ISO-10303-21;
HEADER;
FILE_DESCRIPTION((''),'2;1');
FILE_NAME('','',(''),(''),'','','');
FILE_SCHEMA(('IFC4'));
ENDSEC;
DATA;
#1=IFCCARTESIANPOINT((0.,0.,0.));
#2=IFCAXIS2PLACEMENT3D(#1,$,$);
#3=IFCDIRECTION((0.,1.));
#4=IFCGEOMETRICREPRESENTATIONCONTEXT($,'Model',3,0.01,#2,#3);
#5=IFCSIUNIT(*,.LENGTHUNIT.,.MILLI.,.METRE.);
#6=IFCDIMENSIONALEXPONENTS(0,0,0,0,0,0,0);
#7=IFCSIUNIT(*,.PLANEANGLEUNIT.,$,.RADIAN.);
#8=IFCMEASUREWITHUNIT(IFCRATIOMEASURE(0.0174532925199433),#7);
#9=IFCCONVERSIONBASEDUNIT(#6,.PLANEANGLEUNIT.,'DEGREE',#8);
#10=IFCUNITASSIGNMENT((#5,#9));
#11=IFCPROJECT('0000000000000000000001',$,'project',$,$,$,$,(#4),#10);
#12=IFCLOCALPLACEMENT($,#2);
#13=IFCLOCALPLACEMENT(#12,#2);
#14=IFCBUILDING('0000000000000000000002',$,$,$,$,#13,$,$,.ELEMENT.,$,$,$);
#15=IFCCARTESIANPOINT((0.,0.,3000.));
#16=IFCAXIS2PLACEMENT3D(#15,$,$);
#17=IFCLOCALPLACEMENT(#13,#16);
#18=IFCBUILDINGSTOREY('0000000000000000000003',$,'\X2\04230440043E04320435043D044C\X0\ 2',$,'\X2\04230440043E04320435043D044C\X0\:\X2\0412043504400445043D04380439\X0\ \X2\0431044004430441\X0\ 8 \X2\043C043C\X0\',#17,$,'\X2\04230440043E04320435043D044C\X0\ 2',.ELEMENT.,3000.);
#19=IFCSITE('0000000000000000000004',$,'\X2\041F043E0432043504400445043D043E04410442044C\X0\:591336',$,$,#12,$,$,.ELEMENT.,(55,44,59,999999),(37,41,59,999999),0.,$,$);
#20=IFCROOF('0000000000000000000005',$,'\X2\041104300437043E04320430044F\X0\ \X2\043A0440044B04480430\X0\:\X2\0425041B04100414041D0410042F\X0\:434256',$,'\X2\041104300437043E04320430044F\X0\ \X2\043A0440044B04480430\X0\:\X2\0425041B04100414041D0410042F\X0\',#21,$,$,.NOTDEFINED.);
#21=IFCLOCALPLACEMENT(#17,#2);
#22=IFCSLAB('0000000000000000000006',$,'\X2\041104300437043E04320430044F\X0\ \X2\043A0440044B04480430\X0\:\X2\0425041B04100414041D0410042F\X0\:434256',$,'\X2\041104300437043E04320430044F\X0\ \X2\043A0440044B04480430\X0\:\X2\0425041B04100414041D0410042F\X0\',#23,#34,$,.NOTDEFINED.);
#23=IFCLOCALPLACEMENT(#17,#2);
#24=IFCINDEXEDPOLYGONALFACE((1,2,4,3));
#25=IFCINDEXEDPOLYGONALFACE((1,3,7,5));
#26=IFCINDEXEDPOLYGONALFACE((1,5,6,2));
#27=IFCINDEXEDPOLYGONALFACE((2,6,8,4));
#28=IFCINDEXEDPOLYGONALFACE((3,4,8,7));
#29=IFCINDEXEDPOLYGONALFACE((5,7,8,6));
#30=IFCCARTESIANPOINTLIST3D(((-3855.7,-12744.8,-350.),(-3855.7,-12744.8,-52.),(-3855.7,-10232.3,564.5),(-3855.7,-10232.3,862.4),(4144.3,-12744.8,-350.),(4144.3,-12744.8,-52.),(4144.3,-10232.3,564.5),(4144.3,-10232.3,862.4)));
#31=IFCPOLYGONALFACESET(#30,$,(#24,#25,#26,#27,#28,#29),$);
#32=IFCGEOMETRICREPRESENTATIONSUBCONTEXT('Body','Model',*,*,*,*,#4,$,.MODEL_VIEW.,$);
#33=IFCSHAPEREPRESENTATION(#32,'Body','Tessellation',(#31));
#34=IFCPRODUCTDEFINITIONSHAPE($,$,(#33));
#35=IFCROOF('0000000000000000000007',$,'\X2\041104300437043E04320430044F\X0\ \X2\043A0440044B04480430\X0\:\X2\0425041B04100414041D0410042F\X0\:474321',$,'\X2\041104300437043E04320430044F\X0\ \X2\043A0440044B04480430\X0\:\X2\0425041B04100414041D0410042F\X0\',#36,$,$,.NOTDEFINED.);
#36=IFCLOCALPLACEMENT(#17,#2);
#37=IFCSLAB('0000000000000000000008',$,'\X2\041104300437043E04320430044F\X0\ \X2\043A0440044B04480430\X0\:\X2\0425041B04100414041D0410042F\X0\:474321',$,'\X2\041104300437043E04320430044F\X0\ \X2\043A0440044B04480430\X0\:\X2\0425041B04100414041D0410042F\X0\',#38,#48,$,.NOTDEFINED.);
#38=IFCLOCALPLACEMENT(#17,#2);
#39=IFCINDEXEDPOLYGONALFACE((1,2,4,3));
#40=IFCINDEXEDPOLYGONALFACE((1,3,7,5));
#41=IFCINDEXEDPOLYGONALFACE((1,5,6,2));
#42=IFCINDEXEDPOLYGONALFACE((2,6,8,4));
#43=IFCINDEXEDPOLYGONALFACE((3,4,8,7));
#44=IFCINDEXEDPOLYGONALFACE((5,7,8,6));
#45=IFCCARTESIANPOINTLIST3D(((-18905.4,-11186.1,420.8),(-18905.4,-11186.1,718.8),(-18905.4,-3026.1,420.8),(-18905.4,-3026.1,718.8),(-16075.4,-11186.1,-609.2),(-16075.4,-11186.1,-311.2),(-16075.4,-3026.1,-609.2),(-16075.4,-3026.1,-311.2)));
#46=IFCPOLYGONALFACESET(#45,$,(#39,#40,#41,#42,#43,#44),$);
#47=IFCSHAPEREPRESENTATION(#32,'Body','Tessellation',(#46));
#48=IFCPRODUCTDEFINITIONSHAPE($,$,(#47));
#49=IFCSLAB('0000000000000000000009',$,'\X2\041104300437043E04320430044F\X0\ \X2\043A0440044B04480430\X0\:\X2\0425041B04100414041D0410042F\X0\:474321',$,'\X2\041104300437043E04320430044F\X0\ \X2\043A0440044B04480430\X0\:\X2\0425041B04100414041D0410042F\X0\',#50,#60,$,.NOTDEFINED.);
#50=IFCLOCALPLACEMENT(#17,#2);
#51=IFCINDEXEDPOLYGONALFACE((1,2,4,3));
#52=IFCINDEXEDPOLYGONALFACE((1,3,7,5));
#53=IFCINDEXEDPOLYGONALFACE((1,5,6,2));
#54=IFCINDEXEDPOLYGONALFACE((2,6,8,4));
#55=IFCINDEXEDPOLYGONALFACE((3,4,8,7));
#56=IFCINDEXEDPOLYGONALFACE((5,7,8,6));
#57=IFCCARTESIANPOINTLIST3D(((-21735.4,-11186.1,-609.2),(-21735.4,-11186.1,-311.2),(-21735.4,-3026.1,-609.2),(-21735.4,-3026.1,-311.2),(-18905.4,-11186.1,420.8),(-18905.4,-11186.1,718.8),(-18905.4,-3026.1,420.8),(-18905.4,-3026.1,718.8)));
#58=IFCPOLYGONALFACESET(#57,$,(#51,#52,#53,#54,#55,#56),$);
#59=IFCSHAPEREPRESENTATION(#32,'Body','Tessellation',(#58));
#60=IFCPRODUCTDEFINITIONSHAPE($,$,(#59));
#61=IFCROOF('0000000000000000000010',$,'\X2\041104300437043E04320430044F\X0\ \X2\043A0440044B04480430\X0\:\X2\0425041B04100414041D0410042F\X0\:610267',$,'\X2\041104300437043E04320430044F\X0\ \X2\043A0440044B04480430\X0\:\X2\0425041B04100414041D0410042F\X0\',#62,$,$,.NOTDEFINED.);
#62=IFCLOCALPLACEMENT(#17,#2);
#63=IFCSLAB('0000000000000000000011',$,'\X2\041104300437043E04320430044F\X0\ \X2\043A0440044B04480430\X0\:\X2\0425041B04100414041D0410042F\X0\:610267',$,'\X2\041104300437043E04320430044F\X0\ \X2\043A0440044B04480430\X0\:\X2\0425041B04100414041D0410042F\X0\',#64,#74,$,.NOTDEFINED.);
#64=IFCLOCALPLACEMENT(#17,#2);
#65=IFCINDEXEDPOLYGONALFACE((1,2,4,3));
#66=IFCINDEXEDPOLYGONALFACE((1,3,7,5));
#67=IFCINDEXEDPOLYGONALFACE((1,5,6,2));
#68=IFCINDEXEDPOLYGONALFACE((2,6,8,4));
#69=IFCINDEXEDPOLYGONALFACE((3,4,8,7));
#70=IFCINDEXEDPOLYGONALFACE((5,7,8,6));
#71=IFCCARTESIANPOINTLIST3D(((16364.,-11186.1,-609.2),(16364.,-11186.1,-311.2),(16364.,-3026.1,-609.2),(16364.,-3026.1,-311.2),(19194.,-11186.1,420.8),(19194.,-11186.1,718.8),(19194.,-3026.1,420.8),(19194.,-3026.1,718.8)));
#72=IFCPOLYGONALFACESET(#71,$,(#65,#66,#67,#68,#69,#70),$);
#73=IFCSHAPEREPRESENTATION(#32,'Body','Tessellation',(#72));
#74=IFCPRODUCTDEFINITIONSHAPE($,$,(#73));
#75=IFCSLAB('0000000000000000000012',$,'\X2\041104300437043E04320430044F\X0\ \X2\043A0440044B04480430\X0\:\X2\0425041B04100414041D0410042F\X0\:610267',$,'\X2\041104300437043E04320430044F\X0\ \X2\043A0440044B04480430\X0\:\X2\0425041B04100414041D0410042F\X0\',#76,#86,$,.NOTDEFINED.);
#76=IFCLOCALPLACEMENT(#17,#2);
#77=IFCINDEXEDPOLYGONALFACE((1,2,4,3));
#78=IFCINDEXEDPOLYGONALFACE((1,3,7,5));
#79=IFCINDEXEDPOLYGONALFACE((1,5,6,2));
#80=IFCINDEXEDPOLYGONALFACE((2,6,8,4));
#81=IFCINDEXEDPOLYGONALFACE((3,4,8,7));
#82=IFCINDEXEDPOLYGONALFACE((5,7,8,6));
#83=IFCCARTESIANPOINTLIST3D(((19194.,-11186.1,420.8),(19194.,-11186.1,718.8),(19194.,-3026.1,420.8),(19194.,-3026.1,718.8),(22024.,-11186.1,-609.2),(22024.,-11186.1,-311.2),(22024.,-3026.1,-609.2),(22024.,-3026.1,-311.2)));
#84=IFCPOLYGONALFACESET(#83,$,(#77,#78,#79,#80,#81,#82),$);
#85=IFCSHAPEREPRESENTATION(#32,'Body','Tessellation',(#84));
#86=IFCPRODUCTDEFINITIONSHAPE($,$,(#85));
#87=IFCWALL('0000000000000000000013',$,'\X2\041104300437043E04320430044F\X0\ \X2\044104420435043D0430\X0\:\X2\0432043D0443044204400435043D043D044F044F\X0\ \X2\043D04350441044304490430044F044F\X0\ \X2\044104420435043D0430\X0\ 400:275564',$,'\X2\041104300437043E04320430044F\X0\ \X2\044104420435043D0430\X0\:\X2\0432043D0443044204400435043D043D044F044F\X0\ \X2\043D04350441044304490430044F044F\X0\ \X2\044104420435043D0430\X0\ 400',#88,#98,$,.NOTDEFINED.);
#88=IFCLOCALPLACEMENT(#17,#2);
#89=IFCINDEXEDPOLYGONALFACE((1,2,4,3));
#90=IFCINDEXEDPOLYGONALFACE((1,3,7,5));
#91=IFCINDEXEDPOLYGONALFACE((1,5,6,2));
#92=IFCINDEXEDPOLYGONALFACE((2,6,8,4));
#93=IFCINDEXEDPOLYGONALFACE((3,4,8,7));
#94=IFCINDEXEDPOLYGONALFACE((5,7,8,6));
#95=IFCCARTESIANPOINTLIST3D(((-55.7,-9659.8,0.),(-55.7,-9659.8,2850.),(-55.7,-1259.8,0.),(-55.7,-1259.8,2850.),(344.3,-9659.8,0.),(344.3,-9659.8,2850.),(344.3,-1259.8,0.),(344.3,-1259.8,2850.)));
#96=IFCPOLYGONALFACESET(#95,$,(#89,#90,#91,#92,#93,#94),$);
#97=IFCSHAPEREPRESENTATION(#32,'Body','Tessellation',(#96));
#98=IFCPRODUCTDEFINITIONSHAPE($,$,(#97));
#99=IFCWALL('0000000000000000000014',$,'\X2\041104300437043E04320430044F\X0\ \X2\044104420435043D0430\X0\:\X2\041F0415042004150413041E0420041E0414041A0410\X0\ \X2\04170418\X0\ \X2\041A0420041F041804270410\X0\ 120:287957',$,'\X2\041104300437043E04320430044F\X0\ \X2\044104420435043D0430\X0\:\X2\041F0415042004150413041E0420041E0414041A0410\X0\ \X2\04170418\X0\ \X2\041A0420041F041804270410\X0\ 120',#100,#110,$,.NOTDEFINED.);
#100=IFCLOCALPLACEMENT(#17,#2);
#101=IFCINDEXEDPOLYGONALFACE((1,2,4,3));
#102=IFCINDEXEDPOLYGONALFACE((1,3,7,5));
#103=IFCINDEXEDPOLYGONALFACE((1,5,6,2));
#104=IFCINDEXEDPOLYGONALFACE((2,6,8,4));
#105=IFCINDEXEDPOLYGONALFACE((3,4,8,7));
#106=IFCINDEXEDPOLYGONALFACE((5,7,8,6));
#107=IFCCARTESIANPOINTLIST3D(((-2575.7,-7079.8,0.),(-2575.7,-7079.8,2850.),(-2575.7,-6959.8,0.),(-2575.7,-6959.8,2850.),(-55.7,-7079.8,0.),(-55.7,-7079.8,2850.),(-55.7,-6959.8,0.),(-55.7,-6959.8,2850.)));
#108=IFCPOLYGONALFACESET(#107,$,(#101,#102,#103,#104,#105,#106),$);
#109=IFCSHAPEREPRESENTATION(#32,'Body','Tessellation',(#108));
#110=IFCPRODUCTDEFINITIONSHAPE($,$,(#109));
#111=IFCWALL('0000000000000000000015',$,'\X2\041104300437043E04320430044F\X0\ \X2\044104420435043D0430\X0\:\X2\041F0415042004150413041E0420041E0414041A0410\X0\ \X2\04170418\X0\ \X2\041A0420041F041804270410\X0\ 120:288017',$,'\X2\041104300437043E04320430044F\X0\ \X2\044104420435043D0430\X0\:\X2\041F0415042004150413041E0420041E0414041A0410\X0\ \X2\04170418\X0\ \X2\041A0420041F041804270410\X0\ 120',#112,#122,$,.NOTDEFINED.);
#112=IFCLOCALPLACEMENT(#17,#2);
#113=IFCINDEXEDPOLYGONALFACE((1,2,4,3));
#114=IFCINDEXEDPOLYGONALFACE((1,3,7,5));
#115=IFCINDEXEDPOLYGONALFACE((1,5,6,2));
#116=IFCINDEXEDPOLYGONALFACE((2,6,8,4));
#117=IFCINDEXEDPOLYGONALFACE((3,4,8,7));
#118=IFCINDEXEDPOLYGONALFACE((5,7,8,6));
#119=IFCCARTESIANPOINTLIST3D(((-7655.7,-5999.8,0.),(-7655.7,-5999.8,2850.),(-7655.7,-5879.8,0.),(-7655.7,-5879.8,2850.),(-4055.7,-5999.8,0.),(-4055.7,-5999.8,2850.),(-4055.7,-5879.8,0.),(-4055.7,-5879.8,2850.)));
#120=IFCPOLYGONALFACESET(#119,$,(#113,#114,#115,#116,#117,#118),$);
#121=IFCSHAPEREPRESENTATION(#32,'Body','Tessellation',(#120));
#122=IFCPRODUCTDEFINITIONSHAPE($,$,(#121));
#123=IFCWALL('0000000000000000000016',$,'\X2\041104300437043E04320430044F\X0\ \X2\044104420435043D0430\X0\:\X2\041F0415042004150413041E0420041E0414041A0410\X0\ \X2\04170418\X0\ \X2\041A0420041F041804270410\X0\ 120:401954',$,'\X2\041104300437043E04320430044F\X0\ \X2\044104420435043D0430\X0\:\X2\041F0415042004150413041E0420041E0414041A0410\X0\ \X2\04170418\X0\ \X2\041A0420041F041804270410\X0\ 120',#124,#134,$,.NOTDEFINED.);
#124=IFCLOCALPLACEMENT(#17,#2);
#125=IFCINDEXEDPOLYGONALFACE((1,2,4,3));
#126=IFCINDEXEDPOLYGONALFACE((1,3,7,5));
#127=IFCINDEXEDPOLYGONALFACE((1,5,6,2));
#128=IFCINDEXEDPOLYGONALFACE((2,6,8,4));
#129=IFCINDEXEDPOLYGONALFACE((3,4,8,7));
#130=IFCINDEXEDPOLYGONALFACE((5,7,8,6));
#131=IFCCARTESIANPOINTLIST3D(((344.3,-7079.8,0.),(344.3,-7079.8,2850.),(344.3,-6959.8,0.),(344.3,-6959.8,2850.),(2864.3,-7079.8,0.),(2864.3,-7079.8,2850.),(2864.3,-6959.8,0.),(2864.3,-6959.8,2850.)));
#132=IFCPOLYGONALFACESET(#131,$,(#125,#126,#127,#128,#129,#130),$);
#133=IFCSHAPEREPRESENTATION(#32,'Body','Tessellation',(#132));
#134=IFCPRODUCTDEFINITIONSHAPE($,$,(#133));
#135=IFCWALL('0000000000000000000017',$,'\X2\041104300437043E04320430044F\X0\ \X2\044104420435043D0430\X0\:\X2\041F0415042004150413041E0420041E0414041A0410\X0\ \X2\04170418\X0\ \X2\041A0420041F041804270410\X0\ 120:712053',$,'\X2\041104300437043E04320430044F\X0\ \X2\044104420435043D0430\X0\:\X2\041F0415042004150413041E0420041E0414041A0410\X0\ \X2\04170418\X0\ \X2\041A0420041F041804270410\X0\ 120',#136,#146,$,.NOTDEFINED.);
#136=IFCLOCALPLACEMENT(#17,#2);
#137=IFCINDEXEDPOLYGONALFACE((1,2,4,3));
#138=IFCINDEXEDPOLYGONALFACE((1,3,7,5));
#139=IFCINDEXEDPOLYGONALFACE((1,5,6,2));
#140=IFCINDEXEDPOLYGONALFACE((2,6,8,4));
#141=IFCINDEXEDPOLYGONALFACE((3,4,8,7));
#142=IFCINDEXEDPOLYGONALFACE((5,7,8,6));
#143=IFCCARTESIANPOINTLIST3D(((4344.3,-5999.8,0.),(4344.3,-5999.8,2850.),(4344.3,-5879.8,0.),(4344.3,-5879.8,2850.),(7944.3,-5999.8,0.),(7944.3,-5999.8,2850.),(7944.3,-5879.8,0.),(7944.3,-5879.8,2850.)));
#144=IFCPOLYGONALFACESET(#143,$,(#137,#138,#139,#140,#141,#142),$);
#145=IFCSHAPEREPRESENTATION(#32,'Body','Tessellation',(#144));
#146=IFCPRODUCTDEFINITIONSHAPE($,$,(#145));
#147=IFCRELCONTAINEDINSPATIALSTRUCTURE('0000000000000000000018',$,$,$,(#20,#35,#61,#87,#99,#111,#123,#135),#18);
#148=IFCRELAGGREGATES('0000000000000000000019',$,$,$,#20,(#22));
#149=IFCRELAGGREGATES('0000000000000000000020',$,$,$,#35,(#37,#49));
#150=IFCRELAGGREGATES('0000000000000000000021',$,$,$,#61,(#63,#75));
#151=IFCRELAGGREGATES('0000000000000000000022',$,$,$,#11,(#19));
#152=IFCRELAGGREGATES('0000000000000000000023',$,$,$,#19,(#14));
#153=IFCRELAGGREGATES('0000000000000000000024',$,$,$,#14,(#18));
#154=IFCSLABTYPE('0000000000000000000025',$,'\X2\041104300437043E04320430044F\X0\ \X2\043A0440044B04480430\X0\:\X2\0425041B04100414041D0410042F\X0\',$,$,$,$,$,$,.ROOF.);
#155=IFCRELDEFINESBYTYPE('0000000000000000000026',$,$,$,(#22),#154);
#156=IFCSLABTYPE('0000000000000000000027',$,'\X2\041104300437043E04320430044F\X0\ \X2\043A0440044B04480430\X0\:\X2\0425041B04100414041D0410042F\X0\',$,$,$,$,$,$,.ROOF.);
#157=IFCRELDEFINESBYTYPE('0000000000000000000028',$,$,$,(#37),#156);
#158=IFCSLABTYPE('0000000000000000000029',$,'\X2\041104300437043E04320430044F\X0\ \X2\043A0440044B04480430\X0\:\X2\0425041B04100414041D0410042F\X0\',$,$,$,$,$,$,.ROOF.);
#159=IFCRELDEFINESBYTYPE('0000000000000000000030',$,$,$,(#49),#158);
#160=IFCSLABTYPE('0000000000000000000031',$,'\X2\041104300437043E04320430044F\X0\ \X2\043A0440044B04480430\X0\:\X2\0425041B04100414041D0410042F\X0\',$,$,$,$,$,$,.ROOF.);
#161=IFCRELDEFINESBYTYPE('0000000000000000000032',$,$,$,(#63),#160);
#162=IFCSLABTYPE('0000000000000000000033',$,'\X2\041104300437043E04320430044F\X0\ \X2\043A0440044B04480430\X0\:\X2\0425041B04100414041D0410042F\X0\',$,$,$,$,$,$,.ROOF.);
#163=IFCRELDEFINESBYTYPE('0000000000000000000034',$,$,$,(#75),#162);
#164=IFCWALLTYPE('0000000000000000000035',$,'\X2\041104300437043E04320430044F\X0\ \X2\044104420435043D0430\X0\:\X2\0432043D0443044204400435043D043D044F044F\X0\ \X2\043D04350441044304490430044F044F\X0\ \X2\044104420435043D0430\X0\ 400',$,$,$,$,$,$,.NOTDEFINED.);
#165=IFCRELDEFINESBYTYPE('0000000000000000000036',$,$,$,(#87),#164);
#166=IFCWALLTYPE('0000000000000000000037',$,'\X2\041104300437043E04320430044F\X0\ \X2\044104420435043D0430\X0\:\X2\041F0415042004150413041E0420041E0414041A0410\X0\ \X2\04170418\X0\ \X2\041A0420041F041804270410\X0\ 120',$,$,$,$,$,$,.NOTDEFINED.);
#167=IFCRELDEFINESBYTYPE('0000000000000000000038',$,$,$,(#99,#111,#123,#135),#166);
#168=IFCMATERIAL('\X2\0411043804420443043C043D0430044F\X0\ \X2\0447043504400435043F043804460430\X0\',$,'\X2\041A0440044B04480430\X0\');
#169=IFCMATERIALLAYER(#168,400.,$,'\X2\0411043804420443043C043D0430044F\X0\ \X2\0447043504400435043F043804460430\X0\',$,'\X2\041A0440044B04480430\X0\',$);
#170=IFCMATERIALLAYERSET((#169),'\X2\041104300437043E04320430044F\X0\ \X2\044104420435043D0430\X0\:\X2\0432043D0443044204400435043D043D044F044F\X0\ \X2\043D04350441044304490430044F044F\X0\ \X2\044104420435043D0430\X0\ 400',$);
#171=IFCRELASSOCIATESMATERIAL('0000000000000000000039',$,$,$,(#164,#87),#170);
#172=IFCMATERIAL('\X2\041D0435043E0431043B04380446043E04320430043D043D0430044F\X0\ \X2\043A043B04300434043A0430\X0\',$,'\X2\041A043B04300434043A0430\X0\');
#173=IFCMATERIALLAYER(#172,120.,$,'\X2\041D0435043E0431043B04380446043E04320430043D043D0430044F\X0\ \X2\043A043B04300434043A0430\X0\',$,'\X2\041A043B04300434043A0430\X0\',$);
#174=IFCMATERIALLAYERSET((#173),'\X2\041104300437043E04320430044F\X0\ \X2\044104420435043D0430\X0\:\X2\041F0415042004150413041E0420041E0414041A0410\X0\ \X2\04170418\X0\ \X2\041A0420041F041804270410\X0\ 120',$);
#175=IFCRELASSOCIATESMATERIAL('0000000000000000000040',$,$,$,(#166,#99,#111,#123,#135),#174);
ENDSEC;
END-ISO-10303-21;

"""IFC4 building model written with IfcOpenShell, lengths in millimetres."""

from ifc_helpers import new_model, entity, si_unit, converted_unit, direction, frame, origin, place, context, subcontext, project, spatial, indexed_curve, outline, extrude, material, layer, layer_set, type_object, element, aggregate, save


model = new_model("IFC4")

# Units and contexts
model_context = context("Model", 3, precision=0.01, world=origin(), true_north=direction((0.0, 1.0)))
body_context = subcontext(model_context, "Body", "Model", "MODEL_VIEW")
ifc_project = project(units=[si_unit("LENGTHUNIT", "METRE", prefix="MILLI"), converted_unit("PLANEANGLEUNIT", "DEGREE", entity("IfcRatioMeasure", 0.0174532925199433), si_unit("PLANEANGLEUNIT", "RADIAN"), dimensions=[0, 0, 0, 0, 0, 0, 0])], contexts=[model_context])

# Site, building, storey
site_placement = place(None, origin())
site = spatial("IfcSite", under=ifc_project, at=site_placement, Name="Поверхность:591336", CompositionType="ELEMENT", RefLatitude=(55, 44, 59, 999999), RefLongitude=(37, 41, 59, 999999), RefElevation=0.0)
building_placement = place(site_placement, origin())
building = spatial("IfcBuilding", under=site, at=building_placement, CompositionType="ELEMENT")
storey_placement = place(building_placement, frame((0.0, 0.0, 3000.0)))
storey = spatial("IfcBuildingStorey", under=building, at=storey_placement, Name="Уровень 2", ObjectType="Уровень:Верхний брус 8 мм", LongName="Уровень 2", CompositionType="ELEMENT", Elevation=3000.0)

# Roof, slab
roof_1_placement = place(storey_placement, frame((-3855.7, -12744.8, -350.0)))
roof_1 = element("IfcRoof", 1, at=roof_1_placement, inside=storey, Name="Базовая крыша:ХЛАДНАЯ:434256", ObjectType="Базовая крыша:ХЛАДНАЯ", PredefinedType="NOTDEFINED")
slab_type_1 = type_object("IfcSlabType", Name="Базовая крыша:ХЛАДНАЯ", PredefinedType="ROOF")
slab_1_placement = place(roof_1_placement, origin())
slab_1 = element("IfcSlab", 2, at=slab_1_placement, type_object=slab_type_1, Name="Базовая крыша:ХЛАДНАЯ:434256", ObjectType="Базовая крыша:ХЛАДНАЯ", PredefinedType="NOTDEFINED", context=body_context, shape_type="SweptSolid", body=[
    extrude(outline(indexed_curve([(-4000.0, 1336.9), (-4000.0, -1336.9), (4000.0, -1336.9), (4000.0, 1336.9), (-4000.0, 1336.9)], self_intersect=False)), frame((4000.0, 1256.2, 457.2), z_axis=(0.0, -0.34202, 0.939693), x_axis=(1.0, 0.0, 0.0)), (0.0, 0.34202, 0.939693), 298.0),
])
aggregate(roof_1, [slab_1])

# Roofs, slabs
roof_2_placement = place(storey_placement, frame((-21735.4, -11186.1, -609.2)))
roof_2 = element("IfcRoof", 3, at=roof_2_placement, inside=storey, Name="Базовая крыша:ХЛАДНАЯ:474321", ObjectType="Базовая крыша:ХЛАДНАЯ", PredefinedType="NOTDEFINED")
slab_type_2 = type_object("IfcSlabType", Name="Базовая крыша:ХЛАДНАЯ", PredefinedType="ROOF")
slab_2_placement = place(roof_2_placement, origin())
slab_2 = element("IfcSlab", 4, at=slab_2_placement, type_object=slab_type_2, Name="Базовая крыша:ХЛАДНАЯ:474321", ObjectType="Базовая крыша:ХЛАДНАЯ", PredefinedType="NOTDEFINED", context=body_context, shape_type="SweptSolid", body=[
    extrude(outline(indexed_curve([(-1505.8, 4080.0), (-1505.8, -4080.0), (1505.8, -4080.0), (1505.8, 4080.0), (-1505.8, 4080.0)], self_intersect=False)), frame((4245.0, 4080.0, 515.0), z_axis=(0.34202, 0.0, 0.939693), x_axis=(0.939693, 0.0, -0.34202)), (-0.34202, 0.0, 0.939693), 298.0),
])
slab_type_3 = type_object("IfcSlabType", Name="Базовая крыша:ХЛАДНАЯ", PredefinedType="ROOF")
slab_3_placement = place(roof_2_placement, origin())
slab_3 = element("IfcSlab", 5, at=slab_3_placement, type_object=slab_type_3, Name="Базовая крыша:ХЛАДНАЯ:474321", ObjectType="Базовая крыша:ХЛАДНАЯ", PredefinedType="NOTDEFINED", context=body_context, shape_type="SweptSolid", body=[
    extrude(outline(indexed_curve([(-1505.8, -4080.0), (1505.8, -4080.0), (1505.8, 4080.0), (-1505.8, 4080.0), (-1505.8, -4080.0)], self_intersect=False)), frame((1415.0, 4080.0, 515.0), z_axis=(-0.34202, 0.0, 0.939693), x_axis=(0.939693, 0.0, 0.34202)), (0.34202, 0.0, 0.939693), 298.0),
])
aggregate(roof_2, [slab_2, slab_3])
roof_3_placement = place(storey_placement, frame((16364.0, -11186.1, -609.2)))
roof_3 = element("IfcRoof", 6, at=roof_3_placement, inside=storey, Name="Базовая крыша:ХЛАДНАЯ:610267", ObjectType="Базовая крыша:ХЛАДНАЯ", PredefinedType="NOTDEFINED")
slab_type_4 = type_object("IfcSlabType", Name="Базовая крыша:ХЛАДНАЯ", PredefinedType="ROOF")
slab_4_placement = place(roof_3_placement, origin())
slab_4 = element("IfcSlab", 7, at=slab_4_placement, type_object=slab_type_4, Name="Базовая крыша:ХЛАДНАЯ:610267", ObjectType="Базовая крыша:ХЛАДНАЯ", PredefinedType="NOTDEFINED", context=body_context, shape_type="SweptSolid", body=[
    extrude(outline(indexed_curve([(-1505.8, -4080.0), (1505.8, -4080.0), (1505.8, 4080.0), (-1505.8, 4080.0), (-1505.8, -4080.0)], self_intersect=False)), frame((1415.0, 4080.0, 515.0), z_axis=(-0.34202, 0.0, 0.939693), x_axis=(0.939693, 0.0, 0.34202)), (0.34202, 0.0, 0.939693), 298.0),
])
slab_type_5 = type_object("IfcSlabType", Name="Базовая крыша:ХЛАДНАЯ", PredefinedType="ROOF")
slab_5_placement = place(roof_3_placement, origin())
slab_5 = element("IfcSlab", 8, at=slab_5_placement, type_object=slab_type_5, Name="Базовая крыша:ХЛАДНАЯ:610267", ObjectType="Базовая крыша:ХЛАДНАЯ", PredefinedType="NOTDEFINED", context=body_context, shape_type="SweptSolid", body=[
    extrude(outline(indexed_curve([(-1505.8, 4080.0), (-1505.8, -4080.0), (1505.8, -4080.0), (1505.8, 4080.0), (-1505.8, 4080.0)], self_intersect=False)), frame((4245.0, 4080.0, 515.0), z_axis=(0.34202, 0.0, 0.939693), x_axis=(0.939693, 0.0, -0.34202)), (-0.34202, 0.0, 0.939693), 298.0),
])
aggregate(roof_3, [slab_4, slab_5])

# Walls
ifc_material_1 = material(Name="Битумная черепица", Category="Крыша")
ifc_layer_1 = layer(ifc_material_1, 400.0, Name="Битумная черепица", Category="Крыша")
ifc_layer_set_1 = layer_set([ifc_layer_1], Name="Базовая стена:внутренняя несущаяя стена 400")
wall_type_1 = type_object("IfcWallType", Name="Базовая стена:внутренняя несущаяя стена 400", PredefinedType="NOTDEFINED", material=ifc_layer_set_1)
wall_1_placement = place(storey_placement, frame((144.3, -1259.8, 0.0), z_axis=(0.0, 0.0, 1.0), x_axis=(0.0, -1.0, 0.0)))
element("IfcWall", 9, at=wall_1_placement, inside=storey, type_object=wall_type_1, material=ifc_layer_set_1, Name="Базовая стена:внутренняя несущаяя стена 400:275564", ObjectType="Базовая стена:внутренняя несущаяя стена 400", PredefinedType="NOTDEFINED", context=body_context, shape_type="SweptSolid", body=[
    extrude(outline(indexed_curve([(8400.0, 200.0), (0.0, 200.0), (0.0, -200.0), (8400.0, -200.0), (8400.0, 200.0)], self_intersect=False)), origin(), (0.0, 0.0, 1.0), 2850.0),
])
ifc_material_2 = material(Name="Необлицованная кладка", Category="Кладка")
ifc_layer_2 = layer(ifc_material_2, 120.0, Name="Необлицованная кладка", Category="Кладка")
ifc_layer_set_2 = layer_set([ifc_layer_2], Name="Базовая стена:ПЕРЕГОРОДКА ЗИ КРПИЧА 120")
wall_type_2 = type_object("IfcWallType", Name="Базовая стена:ПЕРЕГОРОДКА ЗИ КРПИЧА 120", PredefinedType="NOTDEFINED", material=ifc_layer_set_2)
wall_2_placement = place(storey_placement, frame((-2575.7, -7019.8, 0.0)))
element("IfcWall", 10, at=wall_2_placement, inside=storey, type_object=wall_type_2, material=ifc_layer_set_2, Name="Базовая стена:ПЕРЕГОРОДКА ЗИ КРПИЧА 120:287957", ObjectType="Базовая стена:ПЕРЕГОРОДКА ЗИ КРПИЧА 120", PredefinedType="NOTDEFINED", context=body_context, shape_type="SweptSolid", body=[
    extrude(outline(indexed_curve([(2520.0, 60.0), (0.0, 60.0), (0.0, -60.0), (2520.0, -60.0), (2520.0, 60.0)], self_intersect=False)), origin(), (0.0, 0.0, 1.0), 2850.0),
])
wall_3_placement = place(storey_placement, frame((-4055.7, -5939.8, 0.0), z_axis=(0.0, 0.0, 1.0), x_axis=(-1.0, 0.0, 0.0)))
element("IfcWall", 11, at=wall_3_placement, inside=storey, type_object=wall_type_2, material=ifc_layer_set_2, Name="Базовая стена:ПЕРЕГОРОДКА ЗИ КРПИЧА 120:288017", ObjectType="Базовая стена:ПЕРЕГОРОДКА ЗИ КРПИЧА 120", PredefinedType="NOTDEFINED", context=body_context, shape_type="SweptSolid", body=[
    extrude(outline(indexed_curve([(3600.0, 60.0), (0.0, 60.0), (0.0, -60.0), (3600.0, -60.0), (3600.0, 60.0)], self_intersect=False)), origin(), (0.0, 0.0, 1.0), 2850.0),
])
wall_4_placement = place(storey_placement, frame((2864.3, -7019.8, 0.0), z_axis=(0.0, 0.0, 1.0), x_axis=(-1.0, 0.0, 0.0)))
element("IfcWall", 12, at=wall_4_placement, inside=storey, type_object=wall_type_2, material=ifc_layer_set_2, Name="Базовая стена:ПЕРЕГОРОДКА ЗИ КРПИЧА 120:401954", ObjectType="Базовая стена:ПЕРЕГОРОДКА ЗИ КРПИЧА 120", PredefinedType="NOTDEFINED", context=body_context, shape_type="SweptSolid", body=[
    extrude(outline(indexed_curve([(2520.0, 60.0), (0.0, 60.0), (0.0, -60.0), (2520.0, -60.0), (2520.0, 60.0)], self_intersect=False)), origin(), (0.0, 0.0, 1.0), 2850.0),
])
wall_5_placement = place(storey_placement, frame((4344.3, -5939.8, 0.0)))
element("IfcWall", 13, at=wall_5_placement, inside=storey, type_object=wall_type_2, material=ifc_layer_set_2, Name="Базовая стена:ПЕРЕГОРОДКА ЗИ КРПИЧА 120:712053", ObjectType="Базовая стена:ПЕРЕГОРОДКА ЗИ КРПИЧА 120", PredefinedType="NOTDEFINED", context=body_context, shape_type="SweptSolid", body=[
    extrude(outline(indexed_curve([(3600.0, 60.0), (0.0, 60.0), (0.0, -60.0), (3600.0, -60.0), (3600.0, 60.0)], self_intersect=False)), origin(), (0.0, 0.0, 1.0), 2850.0),
])

save(model, "model.ifc")
